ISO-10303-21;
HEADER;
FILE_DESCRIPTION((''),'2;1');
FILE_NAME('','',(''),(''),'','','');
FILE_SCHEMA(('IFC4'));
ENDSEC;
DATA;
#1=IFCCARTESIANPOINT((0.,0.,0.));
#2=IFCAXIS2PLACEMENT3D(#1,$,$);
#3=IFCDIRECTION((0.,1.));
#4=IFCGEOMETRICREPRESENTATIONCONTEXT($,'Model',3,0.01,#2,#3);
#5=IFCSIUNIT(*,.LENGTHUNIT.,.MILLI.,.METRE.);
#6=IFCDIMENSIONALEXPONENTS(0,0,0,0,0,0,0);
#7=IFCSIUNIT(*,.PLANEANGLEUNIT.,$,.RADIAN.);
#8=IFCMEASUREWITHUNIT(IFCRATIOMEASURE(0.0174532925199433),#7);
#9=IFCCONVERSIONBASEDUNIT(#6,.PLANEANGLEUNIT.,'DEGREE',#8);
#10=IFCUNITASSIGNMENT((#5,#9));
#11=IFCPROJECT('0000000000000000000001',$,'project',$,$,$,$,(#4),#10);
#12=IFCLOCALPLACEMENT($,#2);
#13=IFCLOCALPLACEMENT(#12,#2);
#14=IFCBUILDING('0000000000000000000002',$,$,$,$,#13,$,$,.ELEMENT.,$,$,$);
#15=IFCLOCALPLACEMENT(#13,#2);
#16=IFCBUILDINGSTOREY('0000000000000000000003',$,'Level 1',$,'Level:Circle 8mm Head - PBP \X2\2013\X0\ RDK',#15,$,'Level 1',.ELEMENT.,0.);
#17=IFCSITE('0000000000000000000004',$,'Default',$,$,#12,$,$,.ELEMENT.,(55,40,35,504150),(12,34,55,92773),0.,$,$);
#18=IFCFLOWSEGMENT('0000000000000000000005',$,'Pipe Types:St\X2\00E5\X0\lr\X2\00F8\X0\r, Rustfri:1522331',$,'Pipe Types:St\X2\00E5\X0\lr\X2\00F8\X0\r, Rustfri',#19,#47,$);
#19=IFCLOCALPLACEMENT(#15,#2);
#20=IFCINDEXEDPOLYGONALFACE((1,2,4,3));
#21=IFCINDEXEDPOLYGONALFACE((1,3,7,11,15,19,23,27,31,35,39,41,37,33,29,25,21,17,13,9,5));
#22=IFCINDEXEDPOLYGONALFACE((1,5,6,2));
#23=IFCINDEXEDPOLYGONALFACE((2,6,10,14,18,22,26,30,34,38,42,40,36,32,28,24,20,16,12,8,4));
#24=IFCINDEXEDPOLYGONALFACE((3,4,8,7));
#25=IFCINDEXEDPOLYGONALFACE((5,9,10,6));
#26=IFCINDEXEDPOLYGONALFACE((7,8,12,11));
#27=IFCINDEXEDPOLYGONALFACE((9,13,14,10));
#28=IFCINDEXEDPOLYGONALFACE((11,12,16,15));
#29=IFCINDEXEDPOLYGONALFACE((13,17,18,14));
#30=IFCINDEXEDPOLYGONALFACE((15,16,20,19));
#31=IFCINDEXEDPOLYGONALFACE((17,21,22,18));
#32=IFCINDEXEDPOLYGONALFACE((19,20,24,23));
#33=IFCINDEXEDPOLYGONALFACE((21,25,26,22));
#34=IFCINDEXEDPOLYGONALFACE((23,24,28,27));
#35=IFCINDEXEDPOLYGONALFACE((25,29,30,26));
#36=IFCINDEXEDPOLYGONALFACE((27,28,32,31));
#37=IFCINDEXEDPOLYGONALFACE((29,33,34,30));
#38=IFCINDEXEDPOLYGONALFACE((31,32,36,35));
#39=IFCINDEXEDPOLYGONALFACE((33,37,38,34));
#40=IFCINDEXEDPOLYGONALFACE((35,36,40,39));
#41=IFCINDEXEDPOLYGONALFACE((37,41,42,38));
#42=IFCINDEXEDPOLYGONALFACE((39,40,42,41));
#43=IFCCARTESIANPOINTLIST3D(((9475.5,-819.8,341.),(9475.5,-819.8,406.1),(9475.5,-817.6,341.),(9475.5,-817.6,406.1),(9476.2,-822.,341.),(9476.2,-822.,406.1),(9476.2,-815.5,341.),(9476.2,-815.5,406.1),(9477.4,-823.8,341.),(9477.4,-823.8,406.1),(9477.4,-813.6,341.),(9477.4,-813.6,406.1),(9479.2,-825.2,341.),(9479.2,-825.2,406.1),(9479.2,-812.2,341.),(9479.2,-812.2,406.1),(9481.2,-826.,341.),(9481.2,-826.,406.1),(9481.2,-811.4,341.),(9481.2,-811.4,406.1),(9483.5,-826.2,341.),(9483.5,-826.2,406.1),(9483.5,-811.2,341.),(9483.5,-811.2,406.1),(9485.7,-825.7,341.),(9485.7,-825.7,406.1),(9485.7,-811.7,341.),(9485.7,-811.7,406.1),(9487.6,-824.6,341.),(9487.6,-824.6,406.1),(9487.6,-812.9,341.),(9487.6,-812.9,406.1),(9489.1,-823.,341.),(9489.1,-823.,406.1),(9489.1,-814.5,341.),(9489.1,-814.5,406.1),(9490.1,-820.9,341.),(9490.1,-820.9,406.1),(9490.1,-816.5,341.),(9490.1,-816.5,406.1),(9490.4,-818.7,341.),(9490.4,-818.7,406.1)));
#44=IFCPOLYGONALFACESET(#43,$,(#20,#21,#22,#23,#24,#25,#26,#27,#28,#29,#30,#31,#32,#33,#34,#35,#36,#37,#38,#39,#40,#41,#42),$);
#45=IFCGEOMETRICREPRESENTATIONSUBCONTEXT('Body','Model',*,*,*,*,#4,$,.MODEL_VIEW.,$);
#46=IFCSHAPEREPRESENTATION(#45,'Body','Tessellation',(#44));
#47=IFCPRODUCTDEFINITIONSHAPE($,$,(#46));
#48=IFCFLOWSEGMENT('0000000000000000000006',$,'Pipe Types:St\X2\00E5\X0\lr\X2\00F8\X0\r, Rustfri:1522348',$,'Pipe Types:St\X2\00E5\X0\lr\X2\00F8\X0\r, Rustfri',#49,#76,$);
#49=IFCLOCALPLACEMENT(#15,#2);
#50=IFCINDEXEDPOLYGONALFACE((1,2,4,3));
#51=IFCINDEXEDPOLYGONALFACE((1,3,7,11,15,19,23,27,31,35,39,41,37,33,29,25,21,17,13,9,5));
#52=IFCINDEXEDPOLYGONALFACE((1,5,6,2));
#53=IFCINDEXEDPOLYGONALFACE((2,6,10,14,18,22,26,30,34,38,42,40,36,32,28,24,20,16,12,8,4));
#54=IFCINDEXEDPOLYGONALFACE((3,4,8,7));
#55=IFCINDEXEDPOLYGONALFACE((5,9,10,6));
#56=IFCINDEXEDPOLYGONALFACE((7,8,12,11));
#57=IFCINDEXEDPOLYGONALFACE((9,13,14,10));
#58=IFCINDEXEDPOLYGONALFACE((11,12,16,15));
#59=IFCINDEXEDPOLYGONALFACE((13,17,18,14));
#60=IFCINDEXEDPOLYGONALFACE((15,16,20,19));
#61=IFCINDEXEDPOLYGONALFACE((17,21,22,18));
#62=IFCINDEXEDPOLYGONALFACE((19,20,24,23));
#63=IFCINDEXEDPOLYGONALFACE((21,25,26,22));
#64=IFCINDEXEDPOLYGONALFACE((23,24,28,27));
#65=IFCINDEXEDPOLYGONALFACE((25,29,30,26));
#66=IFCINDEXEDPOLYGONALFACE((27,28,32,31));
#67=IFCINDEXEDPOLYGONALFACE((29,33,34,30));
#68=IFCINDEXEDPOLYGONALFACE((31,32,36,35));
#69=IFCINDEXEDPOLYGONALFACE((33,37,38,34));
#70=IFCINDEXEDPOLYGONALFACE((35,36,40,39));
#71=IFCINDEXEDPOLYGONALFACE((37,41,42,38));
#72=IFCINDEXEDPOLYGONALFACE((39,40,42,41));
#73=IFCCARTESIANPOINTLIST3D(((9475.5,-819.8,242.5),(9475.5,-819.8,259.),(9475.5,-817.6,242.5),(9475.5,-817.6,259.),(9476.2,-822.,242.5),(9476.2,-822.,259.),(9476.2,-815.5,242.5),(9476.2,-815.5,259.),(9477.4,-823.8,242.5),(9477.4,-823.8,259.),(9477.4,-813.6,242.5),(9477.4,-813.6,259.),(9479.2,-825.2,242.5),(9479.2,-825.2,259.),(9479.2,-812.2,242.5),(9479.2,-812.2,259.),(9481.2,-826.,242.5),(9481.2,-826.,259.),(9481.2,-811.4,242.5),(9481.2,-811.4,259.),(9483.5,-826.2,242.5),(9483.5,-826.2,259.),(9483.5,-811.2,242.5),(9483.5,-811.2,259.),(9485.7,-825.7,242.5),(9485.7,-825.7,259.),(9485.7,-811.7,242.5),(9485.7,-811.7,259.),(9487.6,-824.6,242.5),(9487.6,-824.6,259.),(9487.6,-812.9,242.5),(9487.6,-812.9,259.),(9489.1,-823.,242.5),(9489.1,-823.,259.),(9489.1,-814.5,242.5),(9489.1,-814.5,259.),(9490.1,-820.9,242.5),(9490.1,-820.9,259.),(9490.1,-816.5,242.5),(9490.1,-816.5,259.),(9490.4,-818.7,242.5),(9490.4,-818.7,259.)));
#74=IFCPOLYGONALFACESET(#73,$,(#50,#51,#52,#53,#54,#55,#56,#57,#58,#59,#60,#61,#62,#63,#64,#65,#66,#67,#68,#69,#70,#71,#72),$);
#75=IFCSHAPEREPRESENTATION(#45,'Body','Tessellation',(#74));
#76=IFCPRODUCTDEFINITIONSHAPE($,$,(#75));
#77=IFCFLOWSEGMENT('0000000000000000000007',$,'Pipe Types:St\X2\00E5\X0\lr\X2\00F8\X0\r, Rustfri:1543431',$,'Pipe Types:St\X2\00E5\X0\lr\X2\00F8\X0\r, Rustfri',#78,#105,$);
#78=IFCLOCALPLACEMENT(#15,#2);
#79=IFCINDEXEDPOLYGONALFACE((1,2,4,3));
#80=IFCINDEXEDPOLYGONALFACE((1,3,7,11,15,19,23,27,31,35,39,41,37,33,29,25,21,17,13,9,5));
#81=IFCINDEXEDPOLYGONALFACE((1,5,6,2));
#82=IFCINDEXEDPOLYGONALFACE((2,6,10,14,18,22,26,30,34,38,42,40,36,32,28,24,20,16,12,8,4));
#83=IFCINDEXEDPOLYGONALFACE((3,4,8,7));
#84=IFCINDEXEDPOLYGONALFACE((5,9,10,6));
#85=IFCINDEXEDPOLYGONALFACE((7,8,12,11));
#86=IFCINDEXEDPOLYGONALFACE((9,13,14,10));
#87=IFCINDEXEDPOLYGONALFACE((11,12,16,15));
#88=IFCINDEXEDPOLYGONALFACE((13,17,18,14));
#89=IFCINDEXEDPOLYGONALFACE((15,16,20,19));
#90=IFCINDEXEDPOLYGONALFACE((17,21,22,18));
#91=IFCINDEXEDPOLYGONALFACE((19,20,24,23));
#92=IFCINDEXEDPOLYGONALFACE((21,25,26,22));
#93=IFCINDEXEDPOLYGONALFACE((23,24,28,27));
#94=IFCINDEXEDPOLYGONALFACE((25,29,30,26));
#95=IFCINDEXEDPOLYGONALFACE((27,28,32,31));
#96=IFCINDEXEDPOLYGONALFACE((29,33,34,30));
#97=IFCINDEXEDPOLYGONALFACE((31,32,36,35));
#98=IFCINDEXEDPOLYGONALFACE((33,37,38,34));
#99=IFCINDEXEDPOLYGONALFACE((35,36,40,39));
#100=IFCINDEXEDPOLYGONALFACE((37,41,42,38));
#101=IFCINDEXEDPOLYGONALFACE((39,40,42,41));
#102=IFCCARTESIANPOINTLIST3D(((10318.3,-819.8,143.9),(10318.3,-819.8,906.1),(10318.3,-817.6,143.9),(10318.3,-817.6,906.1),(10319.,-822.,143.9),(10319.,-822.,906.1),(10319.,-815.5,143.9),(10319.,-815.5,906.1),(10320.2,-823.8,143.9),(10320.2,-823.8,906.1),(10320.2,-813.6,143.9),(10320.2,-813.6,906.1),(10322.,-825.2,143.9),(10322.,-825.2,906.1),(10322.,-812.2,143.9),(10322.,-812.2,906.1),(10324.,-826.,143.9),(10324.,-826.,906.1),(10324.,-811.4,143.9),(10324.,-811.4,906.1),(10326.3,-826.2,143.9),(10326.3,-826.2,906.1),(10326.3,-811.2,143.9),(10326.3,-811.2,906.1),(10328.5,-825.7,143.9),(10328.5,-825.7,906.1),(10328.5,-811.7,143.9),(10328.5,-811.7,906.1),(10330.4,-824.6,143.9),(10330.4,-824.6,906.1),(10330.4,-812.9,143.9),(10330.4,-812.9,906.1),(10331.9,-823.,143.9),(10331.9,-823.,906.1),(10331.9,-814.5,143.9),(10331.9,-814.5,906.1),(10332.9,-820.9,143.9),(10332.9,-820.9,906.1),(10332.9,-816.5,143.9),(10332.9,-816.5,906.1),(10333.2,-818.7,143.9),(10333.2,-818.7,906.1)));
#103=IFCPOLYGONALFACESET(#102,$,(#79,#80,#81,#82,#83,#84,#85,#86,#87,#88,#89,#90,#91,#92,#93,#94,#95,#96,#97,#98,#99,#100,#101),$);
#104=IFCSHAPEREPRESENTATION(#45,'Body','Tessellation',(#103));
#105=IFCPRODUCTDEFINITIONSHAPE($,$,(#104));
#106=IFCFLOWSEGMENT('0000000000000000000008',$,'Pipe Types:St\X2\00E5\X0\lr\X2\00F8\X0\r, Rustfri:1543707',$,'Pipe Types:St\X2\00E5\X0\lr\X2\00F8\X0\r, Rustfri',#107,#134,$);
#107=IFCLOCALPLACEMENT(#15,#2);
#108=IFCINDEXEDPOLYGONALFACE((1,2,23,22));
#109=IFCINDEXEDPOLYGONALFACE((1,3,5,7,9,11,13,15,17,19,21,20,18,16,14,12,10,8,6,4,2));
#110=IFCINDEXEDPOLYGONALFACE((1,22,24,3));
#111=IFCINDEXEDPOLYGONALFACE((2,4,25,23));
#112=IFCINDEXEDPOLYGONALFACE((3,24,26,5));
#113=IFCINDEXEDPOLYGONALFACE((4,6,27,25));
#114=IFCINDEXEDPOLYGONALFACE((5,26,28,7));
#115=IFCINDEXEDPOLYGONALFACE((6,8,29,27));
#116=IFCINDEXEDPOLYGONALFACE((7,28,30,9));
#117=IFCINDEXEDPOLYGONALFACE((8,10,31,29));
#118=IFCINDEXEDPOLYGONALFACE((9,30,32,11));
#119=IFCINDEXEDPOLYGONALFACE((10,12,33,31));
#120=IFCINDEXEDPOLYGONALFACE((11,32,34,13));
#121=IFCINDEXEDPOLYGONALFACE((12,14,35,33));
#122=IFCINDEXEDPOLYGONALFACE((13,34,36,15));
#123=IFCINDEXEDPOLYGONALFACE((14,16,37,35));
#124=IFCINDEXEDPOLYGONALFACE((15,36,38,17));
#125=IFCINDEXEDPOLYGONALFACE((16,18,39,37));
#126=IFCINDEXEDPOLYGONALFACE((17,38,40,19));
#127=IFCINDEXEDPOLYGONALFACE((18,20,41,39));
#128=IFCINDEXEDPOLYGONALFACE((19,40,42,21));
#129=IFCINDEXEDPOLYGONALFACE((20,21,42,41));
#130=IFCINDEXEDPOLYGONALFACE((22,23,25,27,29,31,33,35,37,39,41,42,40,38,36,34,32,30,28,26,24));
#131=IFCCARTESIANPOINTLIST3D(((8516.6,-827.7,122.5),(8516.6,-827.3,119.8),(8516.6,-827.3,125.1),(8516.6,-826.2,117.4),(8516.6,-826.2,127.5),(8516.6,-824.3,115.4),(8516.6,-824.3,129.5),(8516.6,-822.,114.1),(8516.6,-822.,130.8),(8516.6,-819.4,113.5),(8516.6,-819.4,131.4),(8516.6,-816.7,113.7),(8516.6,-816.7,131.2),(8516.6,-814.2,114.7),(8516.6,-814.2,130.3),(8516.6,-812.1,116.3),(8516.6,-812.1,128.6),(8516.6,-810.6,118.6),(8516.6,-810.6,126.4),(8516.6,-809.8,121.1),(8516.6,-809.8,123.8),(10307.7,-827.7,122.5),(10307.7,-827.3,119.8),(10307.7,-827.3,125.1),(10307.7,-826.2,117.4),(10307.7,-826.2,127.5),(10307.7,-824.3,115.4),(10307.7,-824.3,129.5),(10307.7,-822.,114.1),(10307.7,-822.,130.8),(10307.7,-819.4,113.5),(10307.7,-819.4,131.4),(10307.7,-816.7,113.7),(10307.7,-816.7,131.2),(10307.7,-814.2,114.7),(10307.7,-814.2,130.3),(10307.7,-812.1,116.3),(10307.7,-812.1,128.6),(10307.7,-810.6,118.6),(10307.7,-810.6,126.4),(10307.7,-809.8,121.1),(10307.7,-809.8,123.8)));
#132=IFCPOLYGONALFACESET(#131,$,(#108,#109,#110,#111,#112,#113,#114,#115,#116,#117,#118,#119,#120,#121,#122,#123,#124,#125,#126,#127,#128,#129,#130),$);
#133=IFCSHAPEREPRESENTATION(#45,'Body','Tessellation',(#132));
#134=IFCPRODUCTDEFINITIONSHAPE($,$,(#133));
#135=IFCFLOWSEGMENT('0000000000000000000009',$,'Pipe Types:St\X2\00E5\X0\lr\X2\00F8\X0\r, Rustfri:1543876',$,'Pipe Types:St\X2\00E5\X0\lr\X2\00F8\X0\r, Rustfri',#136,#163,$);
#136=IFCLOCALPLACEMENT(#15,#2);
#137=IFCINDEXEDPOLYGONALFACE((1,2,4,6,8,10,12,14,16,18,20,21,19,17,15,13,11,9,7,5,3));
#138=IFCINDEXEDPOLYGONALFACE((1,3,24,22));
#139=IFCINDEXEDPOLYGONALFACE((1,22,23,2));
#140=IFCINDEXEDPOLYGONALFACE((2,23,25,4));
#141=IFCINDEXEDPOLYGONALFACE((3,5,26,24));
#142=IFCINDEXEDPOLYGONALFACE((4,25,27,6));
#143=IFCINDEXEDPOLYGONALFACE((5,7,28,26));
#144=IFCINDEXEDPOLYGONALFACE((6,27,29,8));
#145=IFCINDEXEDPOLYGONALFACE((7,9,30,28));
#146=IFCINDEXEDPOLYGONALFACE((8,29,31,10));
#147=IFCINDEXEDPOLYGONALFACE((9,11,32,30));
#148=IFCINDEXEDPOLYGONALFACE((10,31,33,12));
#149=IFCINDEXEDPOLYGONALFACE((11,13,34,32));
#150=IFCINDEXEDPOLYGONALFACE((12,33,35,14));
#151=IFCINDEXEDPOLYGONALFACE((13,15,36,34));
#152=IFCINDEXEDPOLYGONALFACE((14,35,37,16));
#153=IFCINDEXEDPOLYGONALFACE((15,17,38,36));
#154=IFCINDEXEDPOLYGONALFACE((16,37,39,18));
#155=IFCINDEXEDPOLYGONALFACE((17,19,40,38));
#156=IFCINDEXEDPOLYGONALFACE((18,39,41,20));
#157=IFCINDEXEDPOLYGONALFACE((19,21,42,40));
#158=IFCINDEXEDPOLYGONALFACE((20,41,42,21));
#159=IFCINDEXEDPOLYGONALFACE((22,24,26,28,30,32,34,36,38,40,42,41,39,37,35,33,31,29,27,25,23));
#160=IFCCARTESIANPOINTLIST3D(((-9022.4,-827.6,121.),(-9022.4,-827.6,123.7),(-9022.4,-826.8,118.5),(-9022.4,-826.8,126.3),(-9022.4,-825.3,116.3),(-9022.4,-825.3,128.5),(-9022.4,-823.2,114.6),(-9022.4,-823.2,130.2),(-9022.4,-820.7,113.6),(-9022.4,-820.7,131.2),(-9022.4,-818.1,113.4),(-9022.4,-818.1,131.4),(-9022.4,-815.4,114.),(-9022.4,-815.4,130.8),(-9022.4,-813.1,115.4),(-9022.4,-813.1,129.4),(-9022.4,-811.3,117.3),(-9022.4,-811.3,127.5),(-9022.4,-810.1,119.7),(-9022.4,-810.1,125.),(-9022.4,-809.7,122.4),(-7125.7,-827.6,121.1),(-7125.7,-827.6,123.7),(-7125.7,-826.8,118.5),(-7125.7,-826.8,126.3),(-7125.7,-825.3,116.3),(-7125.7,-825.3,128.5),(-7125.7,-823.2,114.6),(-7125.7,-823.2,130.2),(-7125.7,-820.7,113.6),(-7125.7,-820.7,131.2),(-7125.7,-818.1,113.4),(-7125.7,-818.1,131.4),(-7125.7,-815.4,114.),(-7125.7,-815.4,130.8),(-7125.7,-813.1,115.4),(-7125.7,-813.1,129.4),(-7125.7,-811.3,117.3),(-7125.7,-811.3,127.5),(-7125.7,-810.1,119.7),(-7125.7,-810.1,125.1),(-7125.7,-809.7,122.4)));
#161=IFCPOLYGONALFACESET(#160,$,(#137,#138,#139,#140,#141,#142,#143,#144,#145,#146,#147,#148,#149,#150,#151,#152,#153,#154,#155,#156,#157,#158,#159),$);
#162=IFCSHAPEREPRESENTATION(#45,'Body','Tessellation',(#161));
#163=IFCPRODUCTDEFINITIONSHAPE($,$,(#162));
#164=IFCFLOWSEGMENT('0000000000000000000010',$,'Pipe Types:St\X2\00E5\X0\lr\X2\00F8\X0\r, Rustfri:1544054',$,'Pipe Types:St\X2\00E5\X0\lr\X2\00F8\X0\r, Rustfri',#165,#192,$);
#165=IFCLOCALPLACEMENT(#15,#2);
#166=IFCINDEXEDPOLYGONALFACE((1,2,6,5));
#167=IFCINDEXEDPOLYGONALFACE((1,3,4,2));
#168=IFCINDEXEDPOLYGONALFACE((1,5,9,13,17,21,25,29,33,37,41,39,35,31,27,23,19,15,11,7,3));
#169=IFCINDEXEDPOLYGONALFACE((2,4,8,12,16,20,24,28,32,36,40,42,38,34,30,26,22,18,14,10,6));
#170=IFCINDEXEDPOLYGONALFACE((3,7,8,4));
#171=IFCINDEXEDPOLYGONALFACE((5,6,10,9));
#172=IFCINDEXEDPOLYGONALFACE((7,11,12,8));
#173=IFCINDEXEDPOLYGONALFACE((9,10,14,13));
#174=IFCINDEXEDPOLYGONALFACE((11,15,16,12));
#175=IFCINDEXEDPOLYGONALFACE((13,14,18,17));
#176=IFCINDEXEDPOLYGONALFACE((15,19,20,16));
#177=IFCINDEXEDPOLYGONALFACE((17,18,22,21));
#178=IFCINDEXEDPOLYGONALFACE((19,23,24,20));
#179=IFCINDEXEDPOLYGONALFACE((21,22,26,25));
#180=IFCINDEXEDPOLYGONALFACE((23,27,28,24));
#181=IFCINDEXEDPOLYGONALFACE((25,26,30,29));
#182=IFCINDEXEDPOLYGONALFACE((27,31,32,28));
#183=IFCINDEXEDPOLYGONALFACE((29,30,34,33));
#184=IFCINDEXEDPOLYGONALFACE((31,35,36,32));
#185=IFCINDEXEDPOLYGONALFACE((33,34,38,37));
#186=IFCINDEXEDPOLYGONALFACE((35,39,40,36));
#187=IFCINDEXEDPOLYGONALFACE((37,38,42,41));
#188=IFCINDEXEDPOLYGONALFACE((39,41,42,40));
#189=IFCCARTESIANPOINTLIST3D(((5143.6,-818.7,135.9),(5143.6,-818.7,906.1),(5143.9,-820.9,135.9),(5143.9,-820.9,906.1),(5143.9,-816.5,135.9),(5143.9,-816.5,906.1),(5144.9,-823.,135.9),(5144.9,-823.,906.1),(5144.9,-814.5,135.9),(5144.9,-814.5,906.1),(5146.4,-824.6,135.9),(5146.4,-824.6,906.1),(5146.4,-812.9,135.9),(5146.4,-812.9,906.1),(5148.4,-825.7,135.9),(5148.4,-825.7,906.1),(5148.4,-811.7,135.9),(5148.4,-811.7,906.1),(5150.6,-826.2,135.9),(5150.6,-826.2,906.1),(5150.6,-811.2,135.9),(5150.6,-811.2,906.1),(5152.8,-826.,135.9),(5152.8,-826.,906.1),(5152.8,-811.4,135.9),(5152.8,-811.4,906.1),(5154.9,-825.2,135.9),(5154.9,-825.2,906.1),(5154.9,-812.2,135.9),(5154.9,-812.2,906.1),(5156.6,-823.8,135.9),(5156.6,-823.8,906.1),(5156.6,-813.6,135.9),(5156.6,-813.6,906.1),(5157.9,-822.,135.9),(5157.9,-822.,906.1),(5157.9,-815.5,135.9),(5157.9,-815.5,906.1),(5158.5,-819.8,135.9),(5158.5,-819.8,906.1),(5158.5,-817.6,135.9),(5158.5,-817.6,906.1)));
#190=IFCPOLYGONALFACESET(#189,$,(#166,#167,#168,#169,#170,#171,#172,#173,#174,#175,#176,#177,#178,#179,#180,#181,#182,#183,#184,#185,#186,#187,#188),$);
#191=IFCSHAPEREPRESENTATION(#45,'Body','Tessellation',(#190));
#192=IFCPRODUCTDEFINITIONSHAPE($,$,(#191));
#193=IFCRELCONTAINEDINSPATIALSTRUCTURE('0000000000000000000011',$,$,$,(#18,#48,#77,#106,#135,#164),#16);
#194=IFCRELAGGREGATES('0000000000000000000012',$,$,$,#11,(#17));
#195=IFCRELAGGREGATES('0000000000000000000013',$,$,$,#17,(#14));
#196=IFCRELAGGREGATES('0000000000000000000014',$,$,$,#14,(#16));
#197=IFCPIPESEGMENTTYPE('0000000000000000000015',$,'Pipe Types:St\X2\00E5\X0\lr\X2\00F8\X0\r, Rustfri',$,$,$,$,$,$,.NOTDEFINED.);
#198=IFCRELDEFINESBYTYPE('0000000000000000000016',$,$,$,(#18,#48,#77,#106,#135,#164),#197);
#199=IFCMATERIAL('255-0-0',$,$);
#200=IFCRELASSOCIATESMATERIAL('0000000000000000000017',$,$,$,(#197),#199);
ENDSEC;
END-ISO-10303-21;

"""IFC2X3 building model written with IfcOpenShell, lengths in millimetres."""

from ifc_helpers import new_model, entity, si_unit, converted_unit, direction, frame, frame_2d, origin, origin_2d_with_axis, place, context, subcontext, project, spatial, circle, extrude, material, type_object, element, save


model = new_model("IFC2X3")

# Units and contexts
model_context = context("Model", 3, precision=0.01, world=origin(), true_north=direction((0.0, 1.0)))
body_context = subcontext(model_context, "Body", "Model", "MODEL_VIEW")
ifc_project = project(units=[si_unit("LENGTHUNIT", "METRE", prefix="MILLI"), converted_unit("PLANEANGLEUNIT", "DEGREE", entity("IfcRatioMeasure", 0.0174532925199433), si_unit("PLANEANGLEUNIT", "RADIAN"), dimensions=[0, 0, 0, 0, 0, 0, 0])], contexts=[model_context])

# Site, building, storey
site_placement = place(None, origin())
site = spatial("IfcSite", under=ifc_project, at=site_placement, Name="Default", CompositionType="ELEMENT", RefLatitude=(55, 40, 35, 504150), RefLongitude=(12, 34, 55, 92773), RefElevation=0.0)
building_placement = place(site_placement, origin())
building = spatial("IfcBuilding", under=site, at=building_placement, CompositionType="ELEMENT")
storey_placement = place(building_placement, origin())
storey = spatial("IfcBuildingStorey", under=building, at=storey_placement, Name="Level 1", ObjectType="Level:Circle 8mm Head - PBP – RDK", LongName="Level 1", CompositionType="ELEMENT", Elevation=0.0)

# Flow segments
ifc_material_1 = material(Name="255-0-0")
pipe_segment_type = type_object("IfcPipeSegmentType", Name="Pipe Types:Stålrør, Rustfri", PredefinedType="NOTDEFINED", material=ifc_material_1)
flow_segment_1_placement = place(storey_placement, origin())
element("IfcFlowSegment", 1, at=flow_segment_1_placement, inside=storey, type_object=pipe_segment_type, Name="Pipe Types:Stålrør, Rustfri:1522331", ObjectType="Pipe Types:Stålrør, Rustfri", context=body_context, shape_type="SweptSolid", body=[
    extrude(circle(Radius=7.5, at=frame_2d((0.0, 0.0), x_axis=(1.0, 0.0))), frame((9482.9, -818.7, 341.0)), (0.0, 0.0, 1.0), 65.1),
])
flow_segment_2_placement = place(storey_placement, origin())
element("IfcFlowSegment", 2, at=flow_segment_2_placement, inside=storey, type_object=pipe_segment_type, Name="Pipe Types:Stålrør, Rustfri:1522348", ObjectType="Pipe Types:Stålrør, Rustfri", context=body_context, shape_type="SweptSolid", body=[
    extrude(circle(Radius=7.5, at=origin_2d_with_axis()), frame((9482.9, -818.7, 242.5)), (0.0, 0.0, 1.0), 16.5),
])
flow_segment_3_placement = place(storey_placement, origin())
element("IfcFlowSegment", 3, at=flow_segment_3_placement, inside=storey, type_object=pipe_segment_type, Name="Pipe Types:Stålrør, Rustfri:1543431", ObjectType="Pipe Types:Stålrør, Rustfri", context=body_context, shape_type="SweptSolid", body=[
    extrude(circle(Radius=7.5, at=frame_2d((0.0, 0.0), x_axis=(1.0, 0.0))), frame((10325.7, -818.7, 143.9)), (0.0, 0.0, 1.0), 762.2),
])
flow_segment_4_placement = place(storey_placement, origin())
element("IfcFlowSegment", 4, at=flow_segment_4_placement, inside=storey, type_object=pipe_segment_type, Name="Pipe Types:Stålrør, Rustfri:1543707", ObjectType="Pipe Types:Stålrør, Rustfri", context=body_context, shape_type="SweptSolid", body=[
    extrude(circle(Radius=9.0, at=origin_2d_with_axis()), frame((8516.6, -818.7, 122.5), z_axis=(1.0, 0.0, 0.0), x_axis=(0.0, -1.0, 0.0)), (0.0, 0.0, 1.0), 1791.1),
])
flow_segment_5_placement = place(storey_placement, origin())
element("IfcFlowSegment", 5, at=flow_segment_5_placement, inside=storey, type_object=pipe_segment_type, Name="Pipe Types:Stålrør, Rustfri:1543876", ObjectType="Pipe Types:Stålrør, Rustfri", context=body_context, shape_type="SweptSolid", body=[
    extrude(circle(Radius=9.0, at=origin_2d_with_axis()), frame((-9022.4, -818.7, 122.4), z_axis=(1.0, 0.0, 0.000004), x_axis=(0.0, 1.0, 0.0)), (0.0, 0.0, 1.0), 1896.7),
])
flow_segment_6_placement = place(storey_placement, origin())
element("IfcFlowSegment", 6, at=flow_segment_6_placement, inside=storey, type_object=pipe_segment_type, Name="Pipe Types:Stålrør, Rustfri:1544054", ObjectType="Pipe Types:Stålrør, Rustfri", context=body_context, shape_type="SweptSolid", body=[
    extrude(circle(Radius=7.5, at=origin_2d_with_axis()), frame((5151.1, -818.7, 135.9), z_axis=(0.0, 0.0, 1.0), x_axis=(-1.0, 0.0, 0.0)), (0.0, 0.0, 1.0), 770.2),
])

save(model, "model.ifc")
